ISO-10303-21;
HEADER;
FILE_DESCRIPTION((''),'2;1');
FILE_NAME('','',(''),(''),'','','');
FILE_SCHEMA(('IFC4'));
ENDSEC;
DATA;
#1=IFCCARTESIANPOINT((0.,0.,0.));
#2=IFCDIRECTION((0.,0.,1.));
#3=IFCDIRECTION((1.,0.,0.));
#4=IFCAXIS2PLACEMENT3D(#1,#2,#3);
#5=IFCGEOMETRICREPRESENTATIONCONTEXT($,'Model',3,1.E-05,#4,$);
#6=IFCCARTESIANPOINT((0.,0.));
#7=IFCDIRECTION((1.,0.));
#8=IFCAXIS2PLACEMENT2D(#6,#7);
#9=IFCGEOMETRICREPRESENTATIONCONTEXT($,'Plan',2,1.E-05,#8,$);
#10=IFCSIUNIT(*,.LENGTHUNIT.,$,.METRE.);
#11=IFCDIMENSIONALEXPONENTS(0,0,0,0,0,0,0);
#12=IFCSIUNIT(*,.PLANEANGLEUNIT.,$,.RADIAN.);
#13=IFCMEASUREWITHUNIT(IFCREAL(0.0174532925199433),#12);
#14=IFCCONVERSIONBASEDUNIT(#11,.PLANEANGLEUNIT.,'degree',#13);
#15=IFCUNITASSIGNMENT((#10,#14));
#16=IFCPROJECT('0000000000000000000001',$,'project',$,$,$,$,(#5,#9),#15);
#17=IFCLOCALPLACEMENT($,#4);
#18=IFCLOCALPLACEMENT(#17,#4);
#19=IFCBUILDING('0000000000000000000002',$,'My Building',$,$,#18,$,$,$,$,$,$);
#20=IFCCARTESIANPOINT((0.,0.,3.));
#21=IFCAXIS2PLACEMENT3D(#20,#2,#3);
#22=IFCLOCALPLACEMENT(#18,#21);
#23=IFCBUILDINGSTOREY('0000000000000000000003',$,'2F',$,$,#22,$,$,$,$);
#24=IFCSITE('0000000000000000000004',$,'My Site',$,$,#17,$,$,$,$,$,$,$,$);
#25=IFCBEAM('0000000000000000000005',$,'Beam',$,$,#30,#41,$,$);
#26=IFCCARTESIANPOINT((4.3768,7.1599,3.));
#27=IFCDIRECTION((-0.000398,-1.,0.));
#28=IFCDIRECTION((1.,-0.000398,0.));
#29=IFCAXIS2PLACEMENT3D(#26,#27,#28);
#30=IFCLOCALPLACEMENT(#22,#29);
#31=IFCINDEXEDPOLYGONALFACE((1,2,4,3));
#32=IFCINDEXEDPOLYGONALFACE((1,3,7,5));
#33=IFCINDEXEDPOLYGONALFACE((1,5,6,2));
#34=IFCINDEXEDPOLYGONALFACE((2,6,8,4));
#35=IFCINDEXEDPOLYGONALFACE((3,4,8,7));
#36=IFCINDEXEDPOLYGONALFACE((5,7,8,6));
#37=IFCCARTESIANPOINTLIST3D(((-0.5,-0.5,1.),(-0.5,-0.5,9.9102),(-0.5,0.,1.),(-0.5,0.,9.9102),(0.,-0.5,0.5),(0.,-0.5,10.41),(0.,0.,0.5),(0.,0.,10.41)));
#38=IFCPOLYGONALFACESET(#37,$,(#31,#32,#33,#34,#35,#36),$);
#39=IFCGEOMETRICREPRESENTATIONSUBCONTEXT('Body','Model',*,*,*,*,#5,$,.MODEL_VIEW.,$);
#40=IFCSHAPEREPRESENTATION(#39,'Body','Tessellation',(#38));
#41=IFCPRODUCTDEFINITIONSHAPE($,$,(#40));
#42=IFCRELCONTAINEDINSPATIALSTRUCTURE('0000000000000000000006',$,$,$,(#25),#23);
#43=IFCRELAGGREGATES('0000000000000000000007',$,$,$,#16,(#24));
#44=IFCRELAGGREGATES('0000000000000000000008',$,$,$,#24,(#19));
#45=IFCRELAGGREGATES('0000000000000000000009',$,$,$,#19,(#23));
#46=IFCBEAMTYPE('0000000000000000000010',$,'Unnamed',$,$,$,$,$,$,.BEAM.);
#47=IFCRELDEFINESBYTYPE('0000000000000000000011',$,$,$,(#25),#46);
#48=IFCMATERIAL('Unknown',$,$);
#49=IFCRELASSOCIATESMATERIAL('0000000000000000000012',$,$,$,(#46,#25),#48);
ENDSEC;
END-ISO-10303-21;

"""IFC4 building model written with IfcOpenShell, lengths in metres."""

from ifc_helpers import new_model, entity, si_unit, converted_unit, frame, origin_with_axes, origin_2d_with_axis, place, context, subcontext, project, spatial, rectangle, extrude, clip, halfspace, material, material_profile, profile_set, profile_usage, type_object, element, save


model = new_model("IFC4")

# Units and contexts
model_context = context("Model", 3, precision=1e-05, world=origin_with_axes())
plan_context = context("Plan", 2, precision=1e-05, world=origin_2d_with_axis())
body_context_1 = subcontext(model_context, "Body", "Model", "MODEL_VIEW")
ifc_project = project(units=[si_unit("LENGTHUNIT", "METRE"), converted_unit("PLANEANGLEUNIT", "degree", entity("IfcReal", 0.0174532925199433), si_unit("PLANEANGLEUNIT", "RADIAN"), dimensions=[0, 0, 0, 0, 0, 0, 0])], contexts=[model_context, plan_context])

# Site, building, storey
site_placement = place(None, origin_with_axes())
site = spatial("IfcSite", under=ifc_project, at=site_placement, Name="My Site")
building_placement = place(site_placement, origin_with_axes())
building = spatial("IfcBuilding", under=site, at=building_placement, Name="My Building")
storey_placement = place(building_placement, frame((0.0, 0.0, 3.0), z_axis=(0.0, 0.0, 1.0), x_axis=(1.0, 0.0, 0.0)))
storey = spatial("IfcBuildingStorey", under=building, at=storey_placement, Name="2F")

# Shared definitions
ifc_material = material(Name="Unknown")

# Beam
ifc_material_profile_1 = material_profile(ifc_material, rectangle(XDim=0.5, YDim=0.5))
ifc_profile_set_1 = profile_set([ifc_material_profile_1])
beam_type = type_object("IfcBeamType", Name="Unnamed", PredefinedType="BEAM", material=ifc_profile_set_1)
ifc_profile_usage_1 = profile_usage(ifc_profile_set_1, cardinal=7)
beam_1_placement = place(storey_placement, frame((4.3768, 7.1599, 3.0), z_axis=(-0.000398, -1.0, 0.0), x_axis=(1.0, -0.000398, 0.0)))
element("IfcBeam", 1, at=beam_1_placement, inside=storey, type_object=beam_type, material=ifc_profile_usage_1, Name="Beam", context=body_context_1, shape_type="Clipping", body=[
    clip(clip(extrude(rectangle(XDim=0.5, YDim=0.5), frame((-0.25, -0.25, 0.0), z_axis=(0.0, 0.0, 1.0), x_axis=(1.0, 0.0, 0.0)), (0.0, 0.0, 1.0), 10.91), halfspace(frame((0.0, -6.0, 10.41), z_axis=(-0.706966, 0.0, 0.707247), x_axis=(0.0, 1.0, 0.0)), False)), halfspace(frame((0.0, -6.0, 0.5), z_axis=(-0.707114, 0.0, -0.707099), x_axis=(0.0, 1.0, 0.0)), False)),
])

save(model, "model.ifc")
